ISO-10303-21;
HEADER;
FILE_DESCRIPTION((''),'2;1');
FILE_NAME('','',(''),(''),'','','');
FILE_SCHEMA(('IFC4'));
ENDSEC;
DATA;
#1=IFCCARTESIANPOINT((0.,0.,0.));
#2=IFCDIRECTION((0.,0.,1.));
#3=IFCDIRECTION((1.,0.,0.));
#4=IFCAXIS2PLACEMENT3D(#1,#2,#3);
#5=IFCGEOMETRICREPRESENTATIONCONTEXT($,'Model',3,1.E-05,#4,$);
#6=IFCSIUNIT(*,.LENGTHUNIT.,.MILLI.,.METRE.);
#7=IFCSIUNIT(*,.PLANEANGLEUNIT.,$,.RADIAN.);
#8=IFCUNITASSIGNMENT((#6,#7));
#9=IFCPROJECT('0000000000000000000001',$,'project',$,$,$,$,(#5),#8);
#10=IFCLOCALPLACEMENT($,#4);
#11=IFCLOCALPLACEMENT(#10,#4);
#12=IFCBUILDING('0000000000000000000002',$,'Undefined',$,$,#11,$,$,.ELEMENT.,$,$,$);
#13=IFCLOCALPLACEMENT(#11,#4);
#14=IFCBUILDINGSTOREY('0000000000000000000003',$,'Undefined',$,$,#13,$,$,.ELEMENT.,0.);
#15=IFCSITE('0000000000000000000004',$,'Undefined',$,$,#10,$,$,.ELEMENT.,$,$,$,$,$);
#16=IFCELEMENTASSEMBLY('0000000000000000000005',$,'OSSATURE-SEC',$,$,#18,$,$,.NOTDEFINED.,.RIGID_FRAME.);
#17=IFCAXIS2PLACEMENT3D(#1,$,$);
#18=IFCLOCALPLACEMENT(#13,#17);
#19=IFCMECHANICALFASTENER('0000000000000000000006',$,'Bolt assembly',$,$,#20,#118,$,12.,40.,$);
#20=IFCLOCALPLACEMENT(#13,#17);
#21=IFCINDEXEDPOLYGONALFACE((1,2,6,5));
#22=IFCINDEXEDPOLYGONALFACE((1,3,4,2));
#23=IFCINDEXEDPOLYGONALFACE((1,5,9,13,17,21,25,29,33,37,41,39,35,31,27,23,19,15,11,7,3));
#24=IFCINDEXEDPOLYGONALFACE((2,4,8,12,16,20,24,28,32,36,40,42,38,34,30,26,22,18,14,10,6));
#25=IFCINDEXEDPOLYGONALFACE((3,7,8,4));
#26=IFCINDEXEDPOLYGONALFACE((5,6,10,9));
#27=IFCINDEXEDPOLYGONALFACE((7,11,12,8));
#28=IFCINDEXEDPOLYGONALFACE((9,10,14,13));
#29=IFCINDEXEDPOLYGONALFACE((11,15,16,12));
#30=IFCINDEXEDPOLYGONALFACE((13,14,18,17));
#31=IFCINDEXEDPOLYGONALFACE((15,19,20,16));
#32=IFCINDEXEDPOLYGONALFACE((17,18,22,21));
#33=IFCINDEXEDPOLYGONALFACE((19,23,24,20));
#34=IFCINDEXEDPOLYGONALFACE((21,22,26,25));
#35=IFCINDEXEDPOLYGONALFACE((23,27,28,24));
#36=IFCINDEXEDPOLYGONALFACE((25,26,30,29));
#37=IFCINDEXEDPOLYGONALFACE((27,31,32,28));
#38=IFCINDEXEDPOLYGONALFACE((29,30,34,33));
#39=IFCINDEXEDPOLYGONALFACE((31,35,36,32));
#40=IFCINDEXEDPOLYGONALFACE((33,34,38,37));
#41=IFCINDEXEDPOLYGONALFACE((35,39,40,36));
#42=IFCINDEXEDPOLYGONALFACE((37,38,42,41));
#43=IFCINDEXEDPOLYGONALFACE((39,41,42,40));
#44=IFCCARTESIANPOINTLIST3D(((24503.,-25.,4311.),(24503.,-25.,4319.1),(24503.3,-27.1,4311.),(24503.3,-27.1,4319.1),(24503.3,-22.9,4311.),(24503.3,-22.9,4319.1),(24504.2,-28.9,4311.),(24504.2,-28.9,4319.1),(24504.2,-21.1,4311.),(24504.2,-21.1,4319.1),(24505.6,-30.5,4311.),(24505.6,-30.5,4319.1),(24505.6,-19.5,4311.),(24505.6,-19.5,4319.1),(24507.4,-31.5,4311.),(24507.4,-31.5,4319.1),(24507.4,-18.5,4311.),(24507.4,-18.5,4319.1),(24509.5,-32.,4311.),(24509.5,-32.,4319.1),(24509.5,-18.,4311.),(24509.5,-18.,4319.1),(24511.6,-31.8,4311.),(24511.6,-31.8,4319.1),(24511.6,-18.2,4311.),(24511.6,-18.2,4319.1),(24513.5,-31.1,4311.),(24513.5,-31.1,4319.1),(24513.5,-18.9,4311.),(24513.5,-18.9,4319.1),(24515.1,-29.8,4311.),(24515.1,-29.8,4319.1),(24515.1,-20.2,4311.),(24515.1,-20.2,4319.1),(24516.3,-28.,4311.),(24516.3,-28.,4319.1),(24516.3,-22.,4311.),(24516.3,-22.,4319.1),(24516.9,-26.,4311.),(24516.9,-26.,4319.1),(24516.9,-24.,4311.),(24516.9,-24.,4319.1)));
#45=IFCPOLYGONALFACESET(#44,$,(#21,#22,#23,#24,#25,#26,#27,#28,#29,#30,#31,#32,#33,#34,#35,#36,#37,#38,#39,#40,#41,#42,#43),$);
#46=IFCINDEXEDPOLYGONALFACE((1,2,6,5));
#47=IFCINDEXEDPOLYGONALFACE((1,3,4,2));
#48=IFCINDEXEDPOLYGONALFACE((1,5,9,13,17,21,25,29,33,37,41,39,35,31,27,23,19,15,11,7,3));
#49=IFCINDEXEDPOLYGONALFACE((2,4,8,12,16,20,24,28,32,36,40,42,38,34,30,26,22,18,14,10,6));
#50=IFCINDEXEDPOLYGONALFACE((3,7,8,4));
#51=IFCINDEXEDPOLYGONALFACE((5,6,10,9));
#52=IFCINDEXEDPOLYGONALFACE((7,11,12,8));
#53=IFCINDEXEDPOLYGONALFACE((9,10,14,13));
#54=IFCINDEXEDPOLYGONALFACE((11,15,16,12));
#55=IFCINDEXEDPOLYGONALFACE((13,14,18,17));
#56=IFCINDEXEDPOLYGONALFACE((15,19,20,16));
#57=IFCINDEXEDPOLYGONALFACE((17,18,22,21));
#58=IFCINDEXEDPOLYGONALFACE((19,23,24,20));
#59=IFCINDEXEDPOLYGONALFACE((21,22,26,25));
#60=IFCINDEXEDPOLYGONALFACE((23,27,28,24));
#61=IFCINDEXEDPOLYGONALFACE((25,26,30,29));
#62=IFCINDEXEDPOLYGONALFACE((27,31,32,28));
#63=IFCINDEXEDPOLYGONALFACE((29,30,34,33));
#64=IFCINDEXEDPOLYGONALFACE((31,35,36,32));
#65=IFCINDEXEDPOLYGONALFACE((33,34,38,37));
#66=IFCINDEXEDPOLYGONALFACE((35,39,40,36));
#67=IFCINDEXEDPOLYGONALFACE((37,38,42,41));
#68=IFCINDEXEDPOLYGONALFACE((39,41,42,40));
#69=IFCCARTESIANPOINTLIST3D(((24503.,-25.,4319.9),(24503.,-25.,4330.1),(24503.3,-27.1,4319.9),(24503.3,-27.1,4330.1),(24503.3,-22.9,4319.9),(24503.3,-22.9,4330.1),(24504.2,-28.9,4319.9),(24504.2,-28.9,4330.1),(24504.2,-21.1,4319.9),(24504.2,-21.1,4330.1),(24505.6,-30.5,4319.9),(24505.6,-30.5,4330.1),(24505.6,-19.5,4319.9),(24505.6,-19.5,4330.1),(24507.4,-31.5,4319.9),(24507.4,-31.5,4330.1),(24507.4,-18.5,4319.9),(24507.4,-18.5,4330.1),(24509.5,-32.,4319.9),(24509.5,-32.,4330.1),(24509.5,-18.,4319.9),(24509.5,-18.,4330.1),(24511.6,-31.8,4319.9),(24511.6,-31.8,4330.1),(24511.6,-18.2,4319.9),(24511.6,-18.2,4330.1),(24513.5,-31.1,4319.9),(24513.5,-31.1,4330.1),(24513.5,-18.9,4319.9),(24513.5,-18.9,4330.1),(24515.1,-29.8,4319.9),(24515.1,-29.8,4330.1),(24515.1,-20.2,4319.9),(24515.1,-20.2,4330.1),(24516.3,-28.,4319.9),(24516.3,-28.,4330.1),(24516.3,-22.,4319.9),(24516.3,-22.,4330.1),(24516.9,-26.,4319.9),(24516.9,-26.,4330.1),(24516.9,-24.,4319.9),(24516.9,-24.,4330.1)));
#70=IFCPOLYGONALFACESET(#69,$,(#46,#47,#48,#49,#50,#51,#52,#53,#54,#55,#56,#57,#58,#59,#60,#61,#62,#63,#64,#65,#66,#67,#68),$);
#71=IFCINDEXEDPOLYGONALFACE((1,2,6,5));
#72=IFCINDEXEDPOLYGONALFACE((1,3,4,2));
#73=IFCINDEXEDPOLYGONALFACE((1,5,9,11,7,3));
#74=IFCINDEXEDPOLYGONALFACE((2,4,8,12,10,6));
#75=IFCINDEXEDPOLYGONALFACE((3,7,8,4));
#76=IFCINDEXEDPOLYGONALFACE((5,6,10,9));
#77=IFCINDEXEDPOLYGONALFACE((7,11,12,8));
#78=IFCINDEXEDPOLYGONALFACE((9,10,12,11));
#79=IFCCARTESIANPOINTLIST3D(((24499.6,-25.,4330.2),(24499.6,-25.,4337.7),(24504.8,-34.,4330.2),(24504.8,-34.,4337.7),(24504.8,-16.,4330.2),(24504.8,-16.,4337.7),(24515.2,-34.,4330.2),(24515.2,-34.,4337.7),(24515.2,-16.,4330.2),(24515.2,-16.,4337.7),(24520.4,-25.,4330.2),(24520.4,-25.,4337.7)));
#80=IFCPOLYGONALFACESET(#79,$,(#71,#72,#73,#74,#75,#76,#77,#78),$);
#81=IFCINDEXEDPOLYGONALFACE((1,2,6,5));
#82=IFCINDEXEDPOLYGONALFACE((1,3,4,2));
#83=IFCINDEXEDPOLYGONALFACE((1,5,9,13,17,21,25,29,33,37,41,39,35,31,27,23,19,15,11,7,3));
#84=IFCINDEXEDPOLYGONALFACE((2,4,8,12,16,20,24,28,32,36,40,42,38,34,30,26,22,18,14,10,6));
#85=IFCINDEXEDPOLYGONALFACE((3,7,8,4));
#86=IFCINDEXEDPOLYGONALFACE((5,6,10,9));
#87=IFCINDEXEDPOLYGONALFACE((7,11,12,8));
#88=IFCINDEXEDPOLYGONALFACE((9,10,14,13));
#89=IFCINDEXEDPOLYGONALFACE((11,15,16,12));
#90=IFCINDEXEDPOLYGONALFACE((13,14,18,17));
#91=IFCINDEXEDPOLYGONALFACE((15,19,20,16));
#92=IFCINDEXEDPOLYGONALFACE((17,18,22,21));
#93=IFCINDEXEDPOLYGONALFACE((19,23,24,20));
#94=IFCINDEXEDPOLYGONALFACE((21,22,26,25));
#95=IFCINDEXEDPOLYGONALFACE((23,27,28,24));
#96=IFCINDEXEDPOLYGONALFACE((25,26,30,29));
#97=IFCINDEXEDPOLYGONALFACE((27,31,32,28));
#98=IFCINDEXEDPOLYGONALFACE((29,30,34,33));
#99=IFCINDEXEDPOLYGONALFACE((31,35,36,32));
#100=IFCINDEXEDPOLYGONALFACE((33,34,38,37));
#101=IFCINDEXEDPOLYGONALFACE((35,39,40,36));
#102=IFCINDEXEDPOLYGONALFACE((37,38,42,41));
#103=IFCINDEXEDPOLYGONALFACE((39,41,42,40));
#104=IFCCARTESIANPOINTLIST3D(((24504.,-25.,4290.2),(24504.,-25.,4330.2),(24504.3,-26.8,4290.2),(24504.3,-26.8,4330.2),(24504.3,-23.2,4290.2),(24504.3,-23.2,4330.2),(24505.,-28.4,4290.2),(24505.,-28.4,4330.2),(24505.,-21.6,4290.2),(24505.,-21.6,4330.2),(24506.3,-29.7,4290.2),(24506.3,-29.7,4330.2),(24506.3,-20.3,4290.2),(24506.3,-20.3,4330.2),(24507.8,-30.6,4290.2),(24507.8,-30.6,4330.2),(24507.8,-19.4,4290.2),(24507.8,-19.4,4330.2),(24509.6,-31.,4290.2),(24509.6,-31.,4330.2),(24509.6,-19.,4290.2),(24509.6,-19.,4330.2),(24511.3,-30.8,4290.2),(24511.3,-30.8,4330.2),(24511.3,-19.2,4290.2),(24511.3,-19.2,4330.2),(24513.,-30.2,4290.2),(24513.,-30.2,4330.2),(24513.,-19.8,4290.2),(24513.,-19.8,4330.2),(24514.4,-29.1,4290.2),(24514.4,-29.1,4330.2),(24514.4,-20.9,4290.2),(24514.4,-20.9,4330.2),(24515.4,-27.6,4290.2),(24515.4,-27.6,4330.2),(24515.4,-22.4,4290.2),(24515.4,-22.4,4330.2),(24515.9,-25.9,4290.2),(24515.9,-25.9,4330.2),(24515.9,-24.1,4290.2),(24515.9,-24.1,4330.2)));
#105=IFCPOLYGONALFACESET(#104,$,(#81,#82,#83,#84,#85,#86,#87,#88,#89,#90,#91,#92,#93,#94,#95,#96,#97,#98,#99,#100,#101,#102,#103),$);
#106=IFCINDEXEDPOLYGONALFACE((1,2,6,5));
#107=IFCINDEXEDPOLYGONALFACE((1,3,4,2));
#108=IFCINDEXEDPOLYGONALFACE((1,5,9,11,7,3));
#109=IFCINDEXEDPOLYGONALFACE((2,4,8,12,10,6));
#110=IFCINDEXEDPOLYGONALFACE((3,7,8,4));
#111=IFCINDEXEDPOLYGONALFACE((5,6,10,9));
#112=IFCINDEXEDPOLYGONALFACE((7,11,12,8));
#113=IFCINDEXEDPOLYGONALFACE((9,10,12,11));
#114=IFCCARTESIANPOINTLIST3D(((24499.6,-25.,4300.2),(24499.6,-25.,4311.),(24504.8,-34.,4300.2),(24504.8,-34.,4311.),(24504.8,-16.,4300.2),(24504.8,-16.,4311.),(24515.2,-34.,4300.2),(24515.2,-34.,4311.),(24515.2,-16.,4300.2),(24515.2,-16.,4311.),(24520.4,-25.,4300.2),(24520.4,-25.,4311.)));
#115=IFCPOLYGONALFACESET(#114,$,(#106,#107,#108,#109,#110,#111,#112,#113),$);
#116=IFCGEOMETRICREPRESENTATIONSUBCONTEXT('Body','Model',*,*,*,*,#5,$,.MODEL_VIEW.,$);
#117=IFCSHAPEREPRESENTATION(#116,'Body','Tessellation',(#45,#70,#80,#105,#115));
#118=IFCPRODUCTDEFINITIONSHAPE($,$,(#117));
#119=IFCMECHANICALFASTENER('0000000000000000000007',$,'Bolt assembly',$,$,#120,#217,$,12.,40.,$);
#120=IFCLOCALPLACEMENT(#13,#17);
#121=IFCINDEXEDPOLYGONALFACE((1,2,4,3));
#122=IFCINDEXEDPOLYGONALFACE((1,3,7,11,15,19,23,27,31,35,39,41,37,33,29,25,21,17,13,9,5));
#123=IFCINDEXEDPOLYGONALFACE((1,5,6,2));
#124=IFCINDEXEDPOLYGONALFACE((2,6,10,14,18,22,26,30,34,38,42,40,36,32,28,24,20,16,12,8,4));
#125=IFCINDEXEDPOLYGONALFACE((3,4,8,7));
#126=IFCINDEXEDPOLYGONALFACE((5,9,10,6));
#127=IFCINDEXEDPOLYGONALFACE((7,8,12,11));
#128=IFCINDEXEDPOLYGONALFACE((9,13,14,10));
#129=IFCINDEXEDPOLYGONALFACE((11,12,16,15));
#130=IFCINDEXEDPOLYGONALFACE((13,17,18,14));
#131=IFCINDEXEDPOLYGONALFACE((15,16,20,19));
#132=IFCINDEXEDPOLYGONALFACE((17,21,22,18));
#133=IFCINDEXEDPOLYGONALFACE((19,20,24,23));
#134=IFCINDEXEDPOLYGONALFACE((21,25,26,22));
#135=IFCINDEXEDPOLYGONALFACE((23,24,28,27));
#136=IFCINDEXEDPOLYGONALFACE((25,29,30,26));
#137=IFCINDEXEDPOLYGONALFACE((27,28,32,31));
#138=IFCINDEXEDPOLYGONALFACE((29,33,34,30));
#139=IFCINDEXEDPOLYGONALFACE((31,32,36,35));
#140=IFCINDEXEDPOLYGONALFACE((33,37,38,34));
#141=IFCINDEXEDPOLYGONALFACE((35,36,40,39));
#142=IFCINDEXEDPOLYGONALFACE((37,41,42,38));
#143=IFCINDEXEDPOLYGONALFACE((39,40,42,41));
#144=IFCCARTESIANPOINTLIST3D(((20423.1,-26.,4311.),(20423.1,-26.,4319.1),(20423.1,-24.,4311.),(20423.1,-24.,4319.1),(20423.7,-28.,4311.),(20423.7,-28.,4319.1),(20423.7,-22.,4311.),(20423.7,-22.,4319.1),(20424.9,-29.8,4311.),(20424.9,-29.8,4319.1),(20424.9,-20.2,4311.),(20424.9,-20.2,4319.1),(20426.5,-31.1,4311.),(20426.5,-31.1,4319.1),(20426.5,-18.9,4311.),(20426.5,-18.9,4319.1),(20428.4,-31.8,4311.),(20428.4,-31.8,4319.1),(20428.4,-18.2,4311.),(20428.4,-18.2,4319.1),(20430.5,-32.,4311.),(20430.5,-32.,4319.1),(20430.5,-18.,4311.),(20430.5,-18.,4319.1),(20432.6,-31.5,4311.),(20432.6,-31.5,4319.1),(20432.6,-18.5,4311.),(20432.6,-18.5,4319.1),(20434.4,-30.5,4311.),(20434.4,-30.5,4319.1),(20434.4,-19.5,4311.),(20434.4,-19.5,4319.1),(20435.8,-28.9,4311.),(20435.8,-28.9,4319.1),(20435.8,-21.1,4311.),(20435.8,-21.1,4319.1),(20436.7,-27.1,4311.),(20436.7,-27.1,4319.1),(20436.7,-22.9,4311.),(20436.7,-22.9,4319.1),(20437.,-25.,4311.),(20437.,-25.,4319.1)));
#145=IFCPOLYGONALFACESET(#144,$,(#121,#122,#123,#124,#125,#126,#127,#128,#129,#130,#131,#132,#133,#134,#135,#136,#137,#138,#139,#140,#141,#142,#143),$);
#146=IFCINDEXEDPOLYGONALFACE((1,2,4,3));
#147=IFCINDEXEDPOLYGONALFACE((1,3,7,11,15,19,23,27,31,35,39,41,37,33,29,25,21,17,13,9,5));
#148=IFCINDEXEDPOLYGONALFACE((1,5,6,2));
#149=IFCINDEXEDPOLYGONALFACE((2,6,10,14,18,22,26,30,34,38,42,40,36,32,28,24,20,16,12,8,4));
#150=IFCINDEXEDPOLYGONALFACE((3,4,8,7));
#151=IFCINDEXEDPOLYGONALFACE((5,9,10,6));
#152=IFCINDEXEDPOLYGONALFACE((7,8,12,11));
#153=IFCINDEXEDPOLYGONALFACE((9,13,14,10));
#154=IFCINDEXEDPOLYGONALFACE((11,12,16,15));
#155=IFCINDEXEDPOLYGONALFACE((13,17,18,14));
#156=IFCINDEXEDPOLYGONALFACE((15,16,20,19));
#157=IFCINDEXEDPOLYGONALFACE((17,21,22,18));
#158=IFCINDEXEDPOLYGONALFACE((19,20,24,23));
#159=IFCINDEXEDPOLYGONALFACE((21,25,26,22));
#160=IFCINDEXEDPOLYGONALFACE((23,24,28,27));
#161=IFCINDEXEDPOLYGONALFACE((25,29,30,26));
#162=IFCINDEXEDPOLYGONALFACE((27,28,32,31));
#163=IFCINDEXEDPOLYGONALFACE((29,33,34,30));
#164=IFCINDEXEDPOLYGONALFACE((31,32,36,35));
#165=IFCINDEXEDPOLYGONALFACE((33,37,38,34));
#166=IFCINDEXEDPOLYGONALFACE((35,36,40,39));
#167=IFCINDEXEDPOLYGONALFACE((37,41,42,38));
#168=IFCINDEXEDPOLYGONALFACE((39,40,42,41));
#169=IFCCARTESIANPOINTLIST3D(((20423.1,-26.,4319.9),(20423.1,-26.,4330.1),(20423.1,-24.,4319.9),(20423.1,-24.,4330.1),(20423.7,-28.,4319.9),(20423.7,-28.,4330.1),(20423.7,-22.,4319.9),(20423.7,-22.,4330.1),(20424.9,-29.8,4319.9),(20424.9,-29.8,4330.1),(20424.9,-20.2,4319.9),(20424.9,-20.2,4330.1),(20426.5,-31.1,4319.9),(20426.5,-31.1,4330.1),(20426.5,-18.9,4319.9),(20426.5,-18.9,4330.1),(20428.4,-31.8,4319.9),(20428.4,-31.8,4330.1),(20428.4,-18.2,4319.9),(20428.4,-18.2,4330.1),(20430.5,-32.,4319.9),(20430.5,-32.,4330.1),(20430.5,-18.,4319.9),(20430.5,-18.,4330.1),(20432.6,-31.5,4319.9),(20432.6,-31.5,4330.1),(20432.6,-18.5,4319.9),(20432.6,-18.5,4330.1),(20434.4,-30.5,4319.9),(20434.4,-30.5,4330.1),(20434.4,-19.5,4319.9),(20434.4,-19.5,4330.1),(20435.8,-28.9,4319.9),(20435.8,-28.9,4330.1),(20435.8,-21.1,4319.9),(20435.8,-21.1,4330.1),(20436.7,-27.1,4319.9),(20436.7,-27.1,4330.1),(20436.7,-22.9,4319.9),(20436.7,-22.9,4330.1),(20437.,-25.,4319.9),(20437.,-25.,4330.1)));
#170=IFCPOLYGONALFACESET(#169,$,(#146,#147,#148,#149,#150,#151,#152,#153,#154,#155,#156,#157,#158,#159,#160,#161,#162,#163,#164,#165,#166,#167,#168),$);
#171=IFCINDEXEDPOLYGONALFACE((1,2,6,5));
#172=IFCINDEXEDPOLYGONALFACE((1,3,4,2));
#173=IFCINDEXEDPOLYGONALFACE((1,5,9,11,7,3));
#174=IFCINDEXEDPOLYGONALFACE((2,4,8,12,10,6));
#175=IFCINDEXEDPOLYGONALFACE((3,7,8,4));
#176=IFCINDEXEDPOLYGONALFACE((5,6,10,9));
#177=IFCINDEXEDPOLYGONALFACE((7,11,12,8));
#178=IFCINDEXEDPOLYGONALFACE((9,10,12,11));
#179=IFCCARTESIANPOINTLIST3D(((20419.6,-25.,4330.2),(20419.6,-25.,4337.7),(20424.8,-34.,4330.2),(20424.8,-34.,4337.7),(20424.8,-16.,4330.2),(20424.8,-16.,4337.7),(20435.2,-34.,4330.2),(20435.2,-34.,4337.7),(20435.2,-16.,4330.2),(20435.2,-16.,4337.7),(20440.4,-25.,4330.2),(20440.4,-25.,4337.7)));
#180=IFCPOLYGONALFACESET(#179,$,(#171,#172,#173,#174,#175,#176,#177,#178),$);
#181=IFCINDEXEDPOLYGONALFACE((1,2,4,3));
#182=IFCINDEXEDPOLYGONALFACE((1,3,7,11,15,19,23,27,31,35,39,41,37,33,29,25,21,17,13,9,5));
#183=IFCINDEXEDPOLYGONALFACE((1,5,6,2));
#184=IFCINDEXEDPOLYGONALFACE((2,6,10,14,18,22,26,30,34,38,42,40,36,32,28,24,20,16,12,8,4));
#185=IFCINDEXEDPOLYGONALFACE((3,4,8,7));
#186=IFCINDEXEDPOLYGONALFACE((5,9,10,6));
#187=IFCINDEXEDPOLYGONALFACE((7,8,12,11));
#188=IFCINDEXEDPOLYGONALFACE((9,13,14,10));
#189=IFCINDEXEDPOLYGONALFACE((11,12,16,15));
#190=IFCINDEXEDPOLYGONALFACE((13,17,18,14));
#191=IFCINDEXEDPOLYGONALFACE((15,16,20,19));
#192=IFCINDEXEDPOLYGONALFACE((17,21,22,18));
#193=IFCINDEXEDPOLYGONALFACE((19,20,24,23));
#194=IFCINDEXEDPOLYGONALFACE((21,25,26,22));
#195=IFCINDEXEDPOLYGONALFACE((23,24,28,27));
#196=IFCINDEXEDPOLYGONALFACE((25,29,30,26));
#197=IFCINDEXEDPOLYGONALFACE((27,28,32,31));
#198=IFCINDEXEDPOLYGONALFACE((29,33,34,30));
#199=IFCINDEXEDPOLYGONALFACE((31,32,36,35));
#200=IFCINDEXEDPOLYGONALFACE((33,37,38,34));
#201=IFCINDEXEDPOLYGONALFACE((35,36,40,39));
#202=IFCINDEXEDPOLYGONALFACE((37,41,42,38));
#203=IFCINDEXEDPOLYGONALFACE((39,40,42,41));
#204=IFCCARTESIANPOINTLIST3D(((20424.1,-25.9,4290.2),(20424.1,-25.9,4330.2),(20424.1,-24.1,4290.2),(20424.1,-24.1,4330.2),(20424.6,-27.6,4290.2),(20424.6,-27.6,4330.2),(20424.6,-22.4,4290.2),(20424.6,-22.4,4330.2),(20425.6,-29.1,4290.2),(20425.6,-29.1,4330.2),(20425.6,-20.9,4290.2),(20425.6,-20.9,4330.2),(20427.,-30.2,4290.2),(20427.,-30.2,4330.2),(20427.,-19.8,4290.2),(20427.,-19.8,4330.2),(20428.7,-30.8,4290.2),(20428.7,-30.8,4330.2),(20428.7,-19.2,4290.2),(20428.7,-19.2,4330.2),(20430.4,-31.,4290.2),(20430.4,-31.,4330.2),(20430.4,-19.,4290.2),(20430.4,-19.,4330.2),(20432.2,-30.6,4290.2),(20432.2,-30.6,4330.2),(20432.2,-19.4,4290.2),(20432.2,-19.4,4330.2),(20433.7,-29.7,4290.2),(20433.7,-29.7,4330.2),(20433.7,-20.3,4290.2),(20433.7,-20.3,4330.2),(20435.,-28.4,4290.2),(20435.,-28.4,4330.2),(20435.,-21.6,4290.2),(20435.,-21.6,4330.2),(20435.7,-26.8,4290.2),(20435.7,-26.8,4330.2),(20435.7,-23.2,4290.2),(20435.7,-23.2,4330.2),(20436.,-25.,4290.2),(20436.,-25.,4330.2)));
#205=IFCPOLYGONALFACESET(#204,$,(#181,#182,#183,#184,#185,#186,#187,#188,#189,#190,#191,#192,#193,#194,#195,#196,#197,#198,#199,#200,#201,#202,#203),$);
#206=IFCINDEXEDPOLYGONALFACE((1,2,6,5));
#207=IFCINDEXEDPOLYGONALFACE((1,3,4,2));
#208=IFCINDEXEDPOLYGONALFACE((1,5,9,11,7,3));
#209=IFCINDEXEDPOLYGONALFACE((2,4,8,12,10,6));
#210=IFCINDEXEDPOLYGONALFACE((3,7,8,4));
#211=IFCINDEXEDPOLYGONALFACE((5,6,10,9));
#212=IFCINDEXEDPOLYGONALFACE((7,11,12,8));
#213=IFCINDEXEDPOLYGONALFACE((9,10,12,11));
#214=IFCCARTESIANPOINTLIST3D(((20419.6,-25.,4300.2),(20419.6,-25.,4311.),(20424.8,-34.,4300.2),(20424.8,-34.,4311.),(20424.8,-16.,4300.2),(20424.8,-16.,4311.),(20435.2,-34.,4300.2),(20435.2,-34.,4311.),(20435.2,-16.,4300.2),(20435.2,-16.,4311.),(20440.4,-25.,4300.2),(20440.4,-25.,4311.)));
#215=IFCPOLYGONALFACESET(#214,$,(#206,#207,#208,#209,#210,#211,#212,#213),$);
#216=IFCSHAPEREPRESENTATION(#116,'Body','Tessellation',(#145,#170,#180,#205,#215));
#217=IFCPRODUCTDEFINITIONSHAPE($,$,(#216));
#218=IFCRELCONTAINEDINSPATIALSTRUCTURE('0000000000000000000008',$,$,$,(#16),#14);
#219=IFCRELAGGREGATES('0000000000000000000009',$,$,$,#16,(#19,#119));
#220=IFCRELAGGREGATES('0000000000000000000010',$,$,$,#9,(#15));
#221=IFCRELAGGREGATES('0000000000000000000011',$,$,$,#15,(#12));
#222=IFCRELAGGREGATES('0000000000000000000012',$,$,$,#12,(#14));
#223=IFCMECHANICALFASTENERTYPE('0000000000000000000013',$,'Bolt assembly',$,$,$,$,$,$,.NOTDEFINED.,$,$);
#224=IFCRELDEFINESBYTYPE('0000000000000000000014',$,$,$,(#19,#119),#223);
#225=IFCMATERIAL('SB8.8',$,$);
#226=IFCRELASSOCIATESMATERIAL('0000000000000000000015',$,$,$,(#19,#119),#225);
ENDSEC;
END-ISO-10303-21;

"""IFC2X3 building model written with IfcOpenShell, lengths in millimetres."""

from ifc_helpers import new_model, si_unit, frame, origin_with_axes, origin_2d_with_axis, place, context, subcontext, project, spatial, polyline, circle, outline, extrude, source, transform, mapped, material, type_object, element, aggregate, save


model = new_model("IFC2X3")

# Units and contexts
model_context = context("Model", 3, precision=1e-05, world=origin_with_axes())
body_context = subcontext(model_context, "Body", "Model", "MODEL_VIEW")
ifc_project = project(units=[si_unit("LENGTHUNIT", "METRE", prefix="MILLI"), si_unit("PLANEANGLEUNIT", "RADIAN")], contexts=[model_context])

# Site, building, storey
site_placement = place(None, origin_with_axes())
site = spatial("IfcSite", under=ifc_project, at=site_placement, Name="Undefined", CompositionType="ELEMENT")
building_placement = place(site_placement, origin_with_axes())
building = spatial("IfcBuilding", under=site, at=building_placement, Name="Undefined", CompositionType="ELEMENT")
storey_placement = place(building_placement, origin_with_axes())
storey = spatial("IfcBuildingStorey", under=building, at=storey_placement, Name="Undefined", CompositionType="ELEMENT", Elevation=0.0)

# Shared definitions
ifc_material_1 = material(Name="SB8.8")
mechanical_fastener_type = type_object("IfcMechanicalFastenerType", Name="Bolt assembly")

# Element assembly, mechanical fasteners
assembly_1_placement = place(storey_placement, origin_with_axes())
assembly_1 = element("IfcElementAssembly", 1, at=assembly_1_placement, inside=storey, Name="OSSATURE-SEC", AssemblyPlace="NOTDEFINED", PredefinedType="RIGID_FRAME")
shared_shape_1 = source(origin_with_axes(), body_context, "Body", "SweptSolid", [
    extrude(circle(Radius=7.0, at=origin_2d_with_axis()), frame((0.0, 0.9, 0.0), z_axis=(0.0, 1.0, 0.0), x_axis=(1.0, 0.0, 0.0)), (0.0, 0.0, 1.0), 8.1),
    extrude(circle(Radius=7.0, at=origin_2d_with_axis()), frame((0.0, -10.1, 0.0), z_axis=(0.0, 1.0, 0.0), x_axis=(1.0, 0.0, 0.0)), (0.0, 0.0, 1.0), 10.2),
    extrude(outline(polyline([(10.4, 0.0), (5.2, 9.0), (-5.2, 9.0), (-10.4, 0.0), (-5.2, -9.0), (5.2, -9.0), (10.4, 0.0)])), frame((0.0, -17.7, 0.0), z_axis=(0.0, 1.0, 0.0), x_axis=(1.0, 0.0, 0.0)), (0.0, 0.0, 1.0), 7.5),
    extrude(circle(Radius=6.0, at=origin_2d_with_axis()), frame((0.0, -10.2, 0.0), z_axis=(0.0, 1.0, 0.0), x_axis=(1.0, 0.0, 0.0)), (0.0, 0.0, 1.0), 40.0),
    extrude(outline(polyline([(10.4, 0.0), (5.2, 9.0), (-5.2, 9.0), (-10.4, 0.0), (-5.2, -9.0), (5.2, -9.0), (10.4, 0.0)])), frame((0.0, 9.0, 0.0), z_axis=(0.0, 1.0, 0.0), x_axis=(1.0, 0.0, 0.0)), (0.0, 0.0, 1.0), 10.8),
])
mechanical_fastener_1_placement = place(assembly_1_placement, frame((24510.0, -25.0, 4320.0), z_axis=(0.0, -1.0, 0.0), x_axis=(-1.0, 0.0, 0.0)))
mechanical_fastener_1 = element("IfcMechanicalFastener", 2, at=mechanical_fastener_1_placement, type_object=mechanical_fastener_type, material=ifc_material_1, Name="Bolt assembly", NominalDiameter=12.0, NominalLength=40.0, context=body_context, shape_type="MappedRepresentation", body=[
    mapped(shared_shape_1, transform((0.0, 0.0, 0.0))),
])
mechanical_fastener_2_placement = place(assembly_1_placement, frame((20430.0, -25.0, 4320.0), z_axis=(0.0, 1.0, 0.0), x_axis=(1.0, 0.0, 0.0)))
mechanical_fastener_2 = element("IfcMechanicalFastener", 3, at=mechanical_fastener_2_placement, type_object=mechanical_fastener_type, material=ifc_material_1, Name="Bolt assembly", NominalDiameter=12.0, NominalLength=40.0, context=body_context, shape_type="MappedRepresentation", body=[
    mapped(shared_shape_1, transform((0.0, 0.0, 0.0))),
])
aggregate(assembly_1, [mechanical_fastener_1, mechanical_fastener_2])

save(model, "model.ifc")
